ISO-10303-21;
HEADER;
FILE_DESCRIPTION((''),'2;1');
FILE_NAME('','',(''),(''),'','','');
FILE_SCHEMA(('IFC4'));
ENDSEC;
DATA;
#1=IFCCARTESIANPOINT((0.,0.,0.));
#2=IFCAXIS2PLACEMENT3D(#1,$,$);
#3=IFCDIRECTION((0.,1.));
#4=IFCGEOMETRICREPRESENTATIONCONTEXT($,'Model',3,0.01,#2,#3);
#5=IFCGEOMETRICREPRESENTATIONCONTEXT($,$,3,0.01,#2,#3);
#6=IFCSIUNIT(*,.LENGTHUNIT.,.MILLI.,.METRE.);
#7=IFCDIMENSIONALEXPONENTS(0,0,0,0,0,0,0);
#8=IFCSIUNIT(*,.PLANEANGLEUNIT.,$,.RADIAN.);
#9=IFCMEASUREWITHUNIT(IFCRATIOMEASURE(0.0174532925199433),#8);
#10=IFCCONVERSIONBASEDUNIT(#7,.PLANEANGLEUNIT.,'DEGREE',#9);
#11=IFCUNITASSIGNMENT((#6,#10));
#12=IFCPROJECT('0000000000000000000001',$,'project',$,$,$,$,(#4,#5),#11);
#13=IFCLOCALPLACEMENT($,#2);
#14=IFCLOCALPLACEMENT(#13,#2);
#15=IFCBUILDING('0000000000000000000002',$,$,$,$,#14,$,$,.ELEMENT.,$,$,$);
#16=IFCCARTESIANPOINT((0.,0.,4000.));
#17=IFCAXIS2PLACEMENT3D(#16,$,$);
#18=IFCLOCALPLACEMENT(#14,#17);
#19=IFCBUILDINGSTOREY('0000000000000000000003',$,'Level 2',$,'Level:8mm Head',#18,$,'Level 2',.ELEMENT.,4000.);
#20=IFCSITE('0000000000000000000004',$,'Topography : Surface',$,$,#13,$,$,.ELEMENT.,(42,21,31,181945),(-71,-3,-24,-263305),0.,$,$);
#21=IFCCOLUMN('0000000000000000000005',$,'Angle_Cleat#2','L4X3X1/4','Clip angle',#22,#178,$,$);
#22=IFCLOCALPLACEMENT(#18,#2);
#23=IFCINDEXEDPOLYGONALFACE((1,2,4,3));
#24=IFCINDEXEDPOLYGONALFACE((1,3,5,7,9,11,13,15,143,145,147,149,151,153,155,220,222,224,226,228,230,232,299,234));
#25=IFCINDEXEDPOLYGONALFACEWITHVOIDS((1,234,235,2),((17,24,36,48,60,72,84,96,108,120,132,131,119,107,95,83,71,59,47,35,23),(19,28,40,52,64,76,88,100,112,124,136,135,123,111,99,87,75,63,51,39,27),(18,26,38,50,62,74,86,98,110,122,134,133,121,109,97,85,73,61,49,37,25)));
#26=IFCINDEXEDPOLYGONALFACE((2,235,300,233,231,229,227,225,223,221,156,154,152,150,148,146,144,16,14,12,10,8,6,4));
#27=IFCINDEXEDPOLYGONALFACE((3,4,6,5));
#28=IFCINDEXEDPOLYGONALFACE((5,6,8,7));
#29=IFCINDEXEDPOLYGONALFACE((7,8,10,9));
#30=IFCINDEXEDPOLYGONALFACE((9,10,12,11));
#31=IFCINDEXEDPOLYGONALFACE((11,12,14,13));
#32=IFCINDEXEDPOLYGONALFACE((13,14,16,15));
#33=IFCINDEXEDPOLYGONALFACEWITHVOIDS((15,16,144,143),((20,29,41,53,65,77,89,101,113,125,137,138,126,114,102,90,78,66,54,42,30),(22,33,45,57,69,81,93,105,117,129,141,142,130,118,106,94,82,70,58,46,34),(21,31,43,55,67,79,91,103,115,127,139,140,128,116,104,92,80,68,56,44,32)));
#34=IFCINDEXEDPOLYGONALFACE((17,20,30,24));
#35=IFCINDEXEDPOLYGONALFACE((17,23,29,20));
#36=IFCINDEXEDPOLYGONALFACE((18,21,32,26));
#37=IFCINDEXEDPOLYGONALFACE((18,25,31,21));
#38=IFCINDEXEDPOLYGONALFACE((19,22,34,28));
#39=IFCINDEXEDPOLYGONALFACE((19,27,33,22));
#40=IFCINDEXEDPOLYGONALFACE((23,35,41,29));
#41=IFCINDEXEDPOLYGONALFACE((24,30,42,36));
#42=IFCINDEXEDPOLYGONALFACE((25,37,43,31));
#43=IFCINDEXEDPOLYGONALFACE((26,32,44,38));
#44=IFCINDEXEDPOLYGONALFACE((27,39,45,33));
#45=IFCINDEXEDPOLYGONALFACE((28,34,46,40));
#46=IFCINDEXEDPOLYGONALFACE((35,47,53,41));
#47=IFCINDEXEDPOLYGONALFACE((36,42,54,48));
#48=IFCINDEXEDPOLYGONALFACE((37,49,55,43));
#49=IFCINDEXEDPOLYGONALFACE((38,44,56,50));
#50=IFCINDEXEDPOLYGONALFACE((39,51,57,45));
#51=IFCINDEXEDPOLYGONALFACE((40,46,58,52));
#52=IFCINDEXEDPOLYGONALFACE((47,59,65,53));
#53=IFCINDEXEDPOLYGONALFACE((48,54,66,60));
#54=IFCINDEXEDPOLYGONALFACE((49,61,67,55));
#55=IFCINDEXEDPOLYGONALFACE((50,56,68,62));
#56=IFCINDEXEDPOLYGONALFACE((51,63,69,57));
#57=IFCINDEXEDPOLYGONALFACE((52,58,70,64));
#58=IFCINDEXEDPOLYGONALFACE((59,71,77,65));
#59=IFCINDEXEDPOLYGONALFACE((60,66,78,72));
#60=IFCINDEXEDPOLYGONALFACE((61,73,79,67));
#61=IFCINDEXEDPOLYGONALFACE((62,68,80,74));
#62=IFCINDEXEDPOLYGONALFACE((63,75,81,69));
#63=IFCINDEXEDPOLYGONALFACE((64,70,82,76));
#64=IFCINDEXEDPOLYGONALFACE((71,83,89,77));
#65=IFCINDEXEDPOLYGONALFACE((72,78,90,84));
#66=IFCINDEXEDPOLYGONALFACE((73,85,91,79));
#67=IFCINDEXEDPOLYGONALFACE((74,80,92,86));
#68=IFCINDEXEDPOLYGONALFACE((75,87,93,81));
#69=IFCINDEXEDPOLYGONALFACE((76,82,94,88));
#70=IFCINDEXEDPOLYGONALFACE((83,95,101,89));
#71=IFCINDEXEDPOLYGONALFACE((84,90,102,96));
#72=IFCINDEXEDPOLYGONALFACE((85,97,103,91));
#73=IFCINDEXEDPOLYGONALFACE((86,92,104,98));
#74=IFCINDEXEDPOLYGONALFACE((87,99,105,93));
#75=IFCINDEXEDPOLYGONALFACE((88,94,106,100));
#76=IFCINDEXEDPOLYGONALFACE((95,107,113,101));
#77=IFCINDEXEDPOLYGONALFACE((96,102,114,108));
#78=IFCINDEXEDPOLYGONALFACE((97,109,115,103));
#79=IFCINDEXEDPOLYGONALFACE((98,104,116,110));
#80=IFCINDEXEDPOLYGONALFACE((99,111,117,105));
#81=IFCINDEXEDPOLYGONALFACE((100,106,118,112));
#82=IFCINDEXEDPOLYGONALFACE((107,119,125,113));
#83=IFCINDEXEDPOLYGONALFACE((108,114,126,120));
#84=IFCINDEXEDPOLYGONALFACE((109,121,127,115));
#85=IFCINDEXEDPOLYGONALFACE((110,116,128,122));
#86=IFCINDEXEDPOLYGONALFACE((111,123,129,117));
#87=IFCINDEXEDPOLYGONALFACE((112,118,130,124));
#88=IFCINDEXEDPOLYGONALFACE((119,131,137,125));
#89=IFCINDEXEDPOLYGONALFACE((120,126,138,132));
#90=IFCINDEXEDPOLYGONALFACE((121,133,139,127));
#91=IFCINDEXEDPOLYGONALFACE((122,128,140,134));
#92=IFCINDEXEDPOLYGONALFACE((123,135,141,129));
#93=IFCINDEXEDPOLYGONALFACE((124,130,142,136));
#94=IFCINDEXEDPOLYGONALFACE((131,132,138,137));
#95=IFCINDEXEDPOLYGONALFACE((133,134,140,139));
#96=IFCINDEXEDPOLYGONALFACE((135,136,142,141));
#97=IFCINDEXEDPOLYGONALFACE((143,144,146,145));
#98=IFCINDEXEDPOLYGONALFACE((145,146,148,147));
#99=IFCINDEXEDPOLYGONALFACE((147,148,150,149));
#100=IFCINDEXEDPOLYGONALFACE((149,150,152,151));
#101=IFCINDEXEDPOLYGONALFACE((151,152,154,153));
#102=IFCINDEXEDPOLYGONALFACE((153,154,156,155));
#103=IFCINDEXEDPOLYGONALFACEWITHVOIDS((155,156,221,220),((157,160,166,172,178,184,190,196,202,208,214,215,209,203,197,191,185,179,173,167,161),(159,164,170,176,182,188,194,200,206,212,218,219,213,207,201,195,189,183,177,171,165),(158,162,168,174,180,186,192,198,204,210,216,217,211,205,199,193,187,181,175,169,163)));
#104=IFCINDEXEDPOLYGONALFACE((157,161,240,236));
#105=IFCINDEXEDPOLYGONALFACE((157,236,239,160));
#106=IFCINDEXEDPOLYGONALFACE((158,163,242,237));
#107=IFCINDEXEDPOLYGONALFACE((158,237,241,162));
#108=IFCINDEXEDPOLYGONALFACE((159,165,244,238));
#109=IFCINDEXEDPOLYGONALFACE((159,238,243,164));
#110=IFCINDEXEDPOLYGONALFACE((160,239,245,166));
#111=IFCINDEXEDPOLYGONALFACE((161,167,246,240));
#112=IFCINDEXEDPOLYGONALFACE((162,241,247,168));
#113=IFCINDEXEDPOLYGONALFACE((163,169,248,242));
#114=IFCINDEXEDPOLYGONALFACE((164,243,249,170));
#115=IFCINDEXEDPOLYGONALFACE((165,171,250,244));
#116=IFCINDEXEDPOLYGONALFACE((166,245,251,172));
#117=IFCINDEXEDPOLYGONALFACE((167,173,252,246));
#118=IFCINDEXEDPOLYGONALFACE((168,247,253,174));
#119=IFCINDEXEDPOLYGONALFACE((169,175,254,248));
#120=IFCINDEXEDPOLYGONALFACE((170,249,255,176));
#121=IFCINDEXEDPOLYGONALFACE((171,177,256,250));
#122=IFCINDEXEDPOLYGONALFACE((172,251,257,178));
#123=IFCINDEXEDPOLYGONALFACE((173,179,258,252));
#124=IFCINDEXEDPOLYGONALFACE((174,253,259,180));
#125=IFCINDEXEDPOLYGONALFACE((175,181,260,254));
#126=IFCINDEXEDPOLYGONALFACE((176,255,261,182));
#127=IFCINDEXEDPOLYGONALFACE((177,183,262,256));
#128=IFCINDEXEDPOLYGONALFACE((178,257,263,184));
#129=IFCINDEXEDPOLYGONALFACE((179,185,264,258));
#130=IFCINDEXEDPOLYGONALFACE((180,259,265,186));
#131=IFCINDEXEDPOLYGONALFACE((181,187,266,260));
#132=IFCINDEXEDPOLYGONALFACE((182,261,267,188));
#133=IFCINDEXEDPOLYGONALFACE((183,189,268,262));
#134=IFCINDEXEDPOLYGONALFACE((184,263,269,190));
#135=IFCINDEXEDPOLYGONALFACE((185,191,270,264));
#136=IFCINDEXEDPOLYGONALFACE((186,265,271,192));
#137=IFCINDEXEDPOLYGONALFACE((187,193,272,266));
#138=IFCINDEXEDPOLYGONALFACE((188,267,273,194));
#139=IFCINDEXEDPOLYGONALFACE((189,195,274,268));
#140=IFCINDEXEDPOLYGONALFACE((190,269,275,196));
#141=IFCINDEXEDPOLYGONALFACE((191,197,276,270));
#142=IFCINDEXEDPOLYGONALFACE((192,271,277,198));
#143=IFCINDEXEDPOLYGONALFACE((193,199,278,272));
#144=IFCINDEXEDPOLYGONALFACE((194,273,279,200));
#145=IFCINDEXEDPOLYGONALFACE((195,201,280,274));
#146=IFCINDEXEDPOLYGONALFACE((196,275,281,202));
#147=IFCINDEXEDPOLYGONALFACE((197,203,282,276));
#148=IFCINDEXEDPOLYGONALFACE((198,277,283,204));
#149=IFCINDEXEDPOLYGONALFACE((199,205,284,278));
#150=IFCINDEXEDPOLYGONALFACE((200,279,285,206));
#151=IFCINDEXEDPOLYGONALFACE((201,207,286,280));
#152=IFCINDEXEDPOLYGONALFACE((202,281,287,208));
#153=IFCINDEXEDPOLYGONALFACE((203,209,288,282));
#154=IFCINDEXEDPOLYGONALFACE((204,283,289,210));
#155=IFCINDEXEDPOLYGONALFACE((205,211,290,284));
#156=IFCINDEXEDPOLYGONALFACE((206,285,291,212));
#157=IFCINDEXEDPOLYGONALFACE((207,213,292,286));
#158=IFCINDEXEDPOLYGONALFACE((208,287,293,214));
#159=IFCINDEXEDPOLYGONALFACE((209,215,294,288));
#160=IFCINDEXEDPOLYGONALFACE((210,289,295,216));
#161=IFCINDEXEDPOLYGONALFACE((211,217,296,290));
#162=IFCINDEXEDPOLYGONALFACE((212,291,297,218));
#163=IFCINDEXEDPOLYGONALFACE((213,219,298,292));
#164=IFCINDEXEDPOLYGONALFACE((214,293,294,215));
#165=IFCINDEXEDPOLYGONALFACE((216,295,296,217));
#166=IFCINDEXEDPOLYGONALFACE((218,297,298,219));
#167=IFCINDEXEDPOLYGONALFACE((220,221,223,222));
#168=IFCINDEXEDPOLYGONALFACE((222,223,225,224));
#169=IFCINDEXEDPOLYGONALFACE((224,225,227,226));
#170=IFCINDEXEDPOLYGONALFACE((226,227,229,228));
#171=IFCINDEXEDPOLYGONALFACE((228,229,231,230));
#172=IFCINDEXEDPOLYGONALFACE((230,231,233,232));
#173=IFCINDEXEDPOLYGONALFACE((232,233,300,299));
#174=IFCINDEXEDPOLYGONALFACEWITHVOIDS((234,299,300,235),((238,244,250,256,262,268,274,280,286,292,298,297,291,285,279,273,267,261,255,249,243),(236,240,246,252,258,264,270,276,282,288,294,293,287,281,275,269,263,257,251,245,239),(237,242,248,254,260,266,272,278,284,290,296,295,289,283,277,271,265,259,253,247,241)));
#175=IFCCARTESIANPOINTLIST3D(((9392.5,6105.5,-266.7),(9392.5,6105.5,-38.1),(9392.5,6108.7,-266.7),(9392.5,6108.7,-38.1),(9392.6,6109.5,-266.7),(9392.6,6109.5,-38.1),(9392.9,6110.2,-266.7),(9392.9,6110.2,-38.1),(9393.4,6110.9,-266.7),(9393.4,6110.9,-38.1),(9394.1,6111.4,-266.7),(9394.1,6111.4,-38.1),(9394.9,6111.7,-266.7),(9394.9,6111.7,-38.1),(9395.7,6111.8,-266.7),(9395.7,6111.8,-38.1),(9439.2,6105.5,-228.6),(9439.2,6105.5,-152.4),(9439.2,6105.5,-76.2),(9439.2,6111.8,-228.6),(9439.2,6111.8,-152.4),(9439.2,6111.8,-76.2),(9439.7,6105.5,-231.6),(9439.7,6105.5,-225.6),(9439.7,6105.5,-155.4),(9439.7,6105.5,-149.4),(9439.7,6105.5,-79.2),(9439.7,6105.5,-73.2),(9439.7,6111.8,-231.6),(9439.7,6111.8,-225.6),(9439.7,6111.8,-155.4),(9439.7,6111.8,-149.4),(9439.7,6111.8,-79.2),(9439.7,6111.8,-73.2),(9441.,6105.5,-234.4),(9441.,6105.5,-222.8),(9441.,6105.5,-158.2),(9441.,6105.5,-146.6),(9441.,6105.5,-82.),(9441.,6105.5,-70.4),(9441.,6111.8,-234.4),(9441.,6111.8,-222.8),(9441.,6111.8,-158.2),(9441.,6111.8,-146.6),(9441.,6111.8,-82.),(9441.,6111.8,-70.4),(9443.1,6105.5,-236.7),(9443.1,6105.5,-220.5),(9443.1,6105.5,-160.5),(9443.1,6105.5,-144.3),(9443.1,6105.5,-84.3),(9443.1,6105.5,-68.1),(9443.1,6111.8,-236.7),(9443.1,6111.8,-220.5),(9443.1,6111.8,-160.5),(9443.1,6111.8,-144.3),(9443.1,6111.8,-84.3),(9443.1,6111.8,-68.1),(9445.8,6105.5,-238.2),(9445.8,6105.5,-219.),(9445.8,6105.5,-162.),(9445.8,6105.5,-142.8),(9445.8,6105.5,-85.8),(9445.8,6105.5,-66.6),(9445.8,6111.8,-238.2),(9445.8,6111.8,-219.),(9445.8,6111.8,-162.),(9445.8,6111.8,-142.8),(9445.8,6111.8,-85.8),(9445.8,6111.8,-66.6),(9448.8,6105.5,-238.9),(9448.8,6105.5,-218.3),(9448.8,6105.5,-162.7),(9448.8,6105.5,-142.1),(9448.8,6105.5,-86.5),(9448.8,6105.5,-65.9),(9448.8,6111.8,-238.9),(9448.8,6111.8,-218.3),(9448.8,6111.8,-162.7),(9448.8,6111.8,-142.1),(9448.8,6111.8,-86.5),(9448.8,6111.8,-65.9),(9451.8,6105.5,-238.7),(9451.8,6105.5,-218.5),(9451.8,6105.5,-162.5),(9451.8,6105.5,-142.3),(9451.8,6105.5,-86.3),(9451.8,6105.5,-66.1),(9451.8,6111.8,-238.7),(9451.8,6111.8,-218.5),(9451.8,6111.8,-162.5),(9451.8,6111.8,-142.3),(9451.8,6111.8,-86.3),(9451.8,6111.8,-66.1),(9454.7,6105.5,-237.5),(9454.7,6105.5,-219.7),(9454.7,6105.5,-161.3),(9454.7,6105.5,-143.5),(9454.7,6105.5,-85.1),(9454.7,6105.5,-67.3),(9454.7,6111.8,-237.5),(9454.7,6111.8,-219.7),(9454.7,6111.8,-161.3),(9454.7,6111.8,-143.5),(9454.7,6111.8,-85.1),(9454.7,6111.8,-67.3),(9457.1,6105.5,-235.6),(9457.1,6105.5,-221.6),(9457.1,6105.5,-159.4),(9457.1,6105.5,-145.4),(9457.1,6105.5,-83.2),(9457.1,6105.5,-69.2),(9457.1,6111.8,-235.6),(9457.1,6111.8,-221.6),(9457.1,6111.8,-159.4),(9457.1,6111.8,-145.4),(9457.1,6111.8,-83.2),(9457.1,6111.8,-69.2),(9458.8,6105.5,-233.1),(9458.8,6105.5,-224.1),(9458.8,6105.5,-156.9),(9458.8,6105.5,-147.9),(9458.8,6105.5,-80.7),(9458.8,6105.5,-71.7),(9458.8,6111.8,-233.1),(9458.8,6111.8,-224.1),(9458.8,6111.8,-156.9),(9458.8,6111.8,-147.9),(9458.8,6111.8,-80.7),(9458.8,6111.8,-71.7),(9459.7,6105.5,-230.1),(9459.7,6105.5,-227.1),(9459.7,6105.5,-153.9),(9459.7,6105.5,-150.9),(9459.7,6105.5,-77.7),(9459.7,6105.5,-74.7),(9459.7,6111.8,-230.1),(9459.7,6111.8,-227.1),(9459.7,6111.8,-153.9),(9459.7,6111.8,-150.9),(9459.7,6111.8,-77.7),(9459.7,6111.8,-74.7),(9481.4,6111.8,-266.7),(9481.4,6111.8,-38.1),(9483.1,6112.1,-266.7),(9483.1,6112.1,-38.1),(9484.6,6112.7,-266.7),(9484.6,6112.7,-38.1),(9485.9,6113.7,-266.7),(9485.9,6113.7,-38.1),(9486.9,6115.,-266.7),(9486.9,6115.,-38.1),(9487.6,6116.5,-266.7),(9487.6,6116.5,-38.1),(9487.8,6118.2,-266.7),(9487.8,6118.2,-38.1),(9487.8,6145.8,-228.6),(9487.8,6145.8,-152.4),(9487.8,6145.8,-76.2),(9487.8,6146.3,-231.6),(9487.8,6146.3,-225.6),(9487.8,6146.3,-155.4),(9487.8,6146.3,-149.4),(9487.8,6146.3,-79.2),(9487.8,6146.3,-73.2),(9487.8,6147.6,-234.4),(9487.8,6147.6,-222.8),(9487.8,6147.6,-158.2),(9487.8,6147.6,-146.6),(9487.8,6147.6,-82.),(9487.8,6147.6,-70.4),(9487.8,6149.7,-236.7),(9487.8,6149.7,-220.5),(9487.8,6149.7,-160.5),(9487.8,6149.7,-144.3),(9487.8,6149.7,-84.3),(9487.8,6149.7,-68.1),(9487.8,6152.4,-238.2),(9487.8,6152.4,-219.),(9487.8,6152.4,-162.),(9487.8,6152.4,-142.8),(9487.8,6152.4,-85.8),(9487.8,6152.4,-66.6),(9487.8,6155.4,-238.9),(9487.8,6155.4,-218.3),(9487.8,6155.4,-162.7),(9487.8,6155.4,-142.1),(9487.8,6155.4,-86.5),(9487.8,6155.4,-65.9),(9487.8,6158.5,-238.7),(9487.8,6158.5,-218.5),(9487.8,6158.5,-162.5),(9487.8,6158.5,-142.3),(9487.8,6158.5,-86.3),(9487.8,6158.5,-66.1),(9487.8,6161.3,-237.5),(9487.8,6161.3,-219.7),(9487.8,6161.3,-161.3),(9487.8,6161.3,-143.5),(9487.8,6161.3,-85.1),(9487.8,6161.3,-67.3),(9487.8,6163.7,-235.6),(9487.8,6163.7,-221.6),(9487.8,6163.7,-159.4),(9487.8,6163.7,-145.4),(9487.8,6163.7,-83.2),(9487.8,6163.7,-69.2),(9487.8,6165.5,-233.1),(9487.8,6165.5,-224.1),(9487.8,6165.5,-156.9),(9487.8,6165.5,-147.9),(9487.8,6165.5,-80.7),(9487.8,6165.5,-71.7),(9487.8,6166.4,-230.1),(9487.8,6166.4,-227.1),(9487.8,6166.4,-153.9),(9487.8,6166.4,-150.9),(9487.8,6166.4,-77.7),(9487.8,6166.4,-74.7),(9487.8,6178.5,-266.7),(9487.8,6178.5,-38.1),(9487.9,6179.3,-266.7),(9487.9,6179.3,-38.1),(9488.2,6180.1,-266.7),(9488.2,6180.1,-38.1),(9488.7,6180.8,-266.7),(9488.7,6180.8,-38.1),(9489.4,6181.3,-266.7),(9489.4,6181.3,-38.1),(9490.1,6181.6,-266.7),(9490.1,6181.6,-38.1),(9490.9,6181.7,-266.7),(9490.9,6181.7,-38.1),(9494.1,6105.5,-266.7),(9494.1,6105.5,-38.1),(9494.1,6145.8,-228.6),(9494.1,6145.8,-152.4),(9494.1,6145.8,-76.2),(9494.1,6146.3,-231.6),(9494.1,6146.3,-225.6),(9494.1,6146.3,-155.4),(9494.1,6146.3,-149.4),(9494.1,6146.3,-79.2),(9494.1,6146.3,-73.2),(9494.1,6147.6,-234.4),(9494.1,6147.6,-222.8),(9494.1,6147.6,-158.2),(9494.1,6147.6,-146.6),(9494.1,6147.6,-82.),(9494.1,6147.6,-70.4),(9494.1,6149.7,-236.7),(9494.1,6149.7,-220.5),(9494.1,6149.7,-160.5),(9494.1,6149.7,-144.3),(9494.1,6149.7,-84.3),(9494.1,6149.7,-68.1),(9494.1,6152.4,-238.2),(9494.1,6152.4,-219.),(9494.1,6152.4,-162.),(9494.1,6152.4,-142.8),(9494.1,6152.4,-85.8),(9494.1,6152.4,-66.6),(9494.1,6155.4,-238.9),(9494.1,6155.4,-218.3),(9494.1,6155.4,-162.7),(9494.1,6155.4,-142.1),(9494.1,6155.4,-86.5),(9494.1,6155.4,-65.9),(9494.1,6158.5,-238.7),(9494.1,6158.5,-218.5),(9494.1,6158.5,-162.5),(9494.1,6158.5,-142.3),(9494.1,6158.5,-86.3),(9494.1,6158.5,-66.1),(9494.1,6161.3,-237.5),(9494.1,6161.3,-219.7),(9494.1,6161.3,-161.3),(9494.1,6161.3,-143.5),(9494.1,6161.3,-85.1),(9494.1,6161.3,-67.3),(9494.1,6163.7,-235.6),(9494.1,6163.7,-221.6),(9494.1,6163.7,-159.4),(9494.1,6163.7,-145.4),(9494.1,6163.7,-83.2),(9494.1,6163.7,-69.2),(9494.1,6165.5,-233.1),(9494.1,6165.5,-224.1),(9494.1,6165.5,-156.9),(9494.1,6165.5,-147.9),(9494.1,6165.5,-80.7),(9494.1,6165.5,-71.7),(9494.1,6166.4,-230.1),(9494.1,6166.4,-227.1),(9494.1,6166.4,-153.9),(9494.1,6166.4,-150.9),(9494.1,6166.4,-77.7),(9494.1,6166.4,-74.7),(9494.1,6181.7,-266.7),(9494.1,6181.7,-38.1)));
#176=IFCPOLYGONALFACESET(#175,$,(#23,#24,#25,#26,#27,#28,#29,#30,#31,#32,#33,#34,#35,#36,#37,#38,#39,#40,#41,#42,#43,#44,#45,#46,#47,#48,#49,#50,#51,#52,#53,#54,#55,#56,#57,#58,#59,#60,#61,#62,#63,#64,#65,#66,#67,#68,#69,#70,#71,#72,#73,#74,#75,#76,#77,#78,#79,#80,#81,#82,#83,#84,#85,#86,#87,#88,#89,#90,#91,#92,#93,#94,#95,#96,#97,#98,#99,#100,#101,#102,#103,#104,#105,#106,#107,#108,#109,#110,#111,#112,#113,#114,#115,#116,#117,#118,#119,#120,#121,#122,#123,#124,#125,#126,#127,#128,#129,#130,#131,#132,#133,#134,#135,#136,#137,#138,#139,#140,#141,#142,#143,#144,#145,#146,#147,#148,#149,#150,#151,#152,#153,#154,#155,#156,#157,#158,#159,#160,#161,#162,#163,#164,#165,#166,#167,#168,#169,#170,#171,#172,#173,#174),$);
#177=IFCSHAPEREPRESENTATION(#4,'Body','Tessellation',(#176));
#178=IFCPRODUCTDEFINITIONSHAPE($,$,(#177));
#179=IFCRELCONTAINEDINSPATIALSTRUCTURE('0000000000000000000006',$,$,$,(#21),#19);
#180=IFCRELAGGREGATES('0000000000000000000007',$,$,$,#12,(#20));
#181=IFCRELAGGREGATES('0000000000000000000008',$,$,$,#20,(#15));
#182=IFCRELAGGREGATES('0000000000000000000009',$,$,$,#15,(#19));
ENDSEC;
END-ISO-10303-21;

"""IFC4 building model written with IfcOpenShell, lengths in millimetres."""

from ifc_helpers import new_model, entity, si_unit, converted_unit, direction, frame, frame_2d, origin, origin_2d_with_axis, place, context, project, spatial, circle, l_section, extrude, element, save


model = new_model("IFC4")

# Units and contexts
model_context = context("Model", 3, precision=0.01, world=origin(), true_north=direction((0.0, 1.0)))
context_of_model = context(None, 3, precision=0.01, world=origin(), true_north=direction((0.0, 1.0)))
ifc_project = project(units=[si_unit("LENGTHUNIT", "METRE", prefix="MILLI"), converted_unit("PLANEANGLEUNIT", "DEGREE", entity("IfcRatioMeasure", 0.0174532925199433), si_unit("PLANEANGLEUNIT", "RADIAN"), dimensions=[0, 0, 0, 0, 0, 0, 0])], contexts=[model_context, context_of_model])

# Site, building, storey
site_placement = place(None, origin())
site = spatial("IfcSite", under=ifc_project, at=site_placement, Name="Topography : Surface", CompositionType="ELEMENT", RefLatitude=(42, 21, 31, 181945), RefLongitude=(-71, -3, -24, -263305), RefElevation=0.0)
building_placement = place(site_placement, origin())
building = spatial("IfcBuilding", under=site, at=building_placement, CompositionType="ELEMENT")
storey_placement = place(building_placement, frame((0.0, 0.0, 4000.0)))
storey = spatial("IfcBuildingStorey", under=building, at=storey_placement, Name="Level 2", ObjectType="Level:8mm Head", LongName="Level 2", CompositionType="ELEMENT", Elevation=4000.0)

# Column, openings
column_1_placement = place(storey_placement, frame((9463.0, 6123.8, -38.1), z_axis=(0.0, 0.0, 1.0), x_axis=(0.0, 1.0, 0.0)))
column_1 = element("IfcColumn", 1, at=column_1_placement, inside=storey, Name="Angle_Cleat#2", Description="L4X3X1/4", ObjectType="Clip angle", context=model_context, shape_type="SweptSolid", body=[
    extrude(l_section(Depth=101.6, Width=76.2, Thickness=6.3, FilletRadius=6.3, EdgeRadius=3.2, at=frame_2d((19.8, 19.7))), origin(), (0.0, 0.0, -1.0), 228.6),
])
opening_1_placement = place(column_1_placement, frame((32.4, -31.5, -114.3), z_axis=(0.0, 1.0, 0.0), x_axis=(-1.0, 0.0, 0.0)))
element("IfcOpeningElement", 2, at=opening_1_placement, cuts=column_1, ObjectType="Opening", context=model_context, shape_type="SweptSolid", body=[
    extrude(circle(Radius=10.3, at=origin_2d_with_axis()), origin(), (0.0, 0.0, 1.0), 7.3),
])
opening_2_placement = place(column_1_placement, frame((32.4, -31.5, -114.3), z_axis=(0.0, 1.0, 0.0), x_axis=(-1.0, 0.0, 0.0)))
element("IfcOpeningElement", 3, at=opening_2_placement, cuts=column_1, ObjectType="Opening", context=model_context, shape_type="SweptSolid", body=[
    extrude(circle(Radius=10.3, at=frame_2d((0.0, 76.2), x_axis=(1.0, 0.0))), origin(), (0.0, 0.0, 1.0), 7.3),
])
opening_3_placement = place(column_1_placement, frame((32.4, -31.5, -114.3), z_axis=(0.0, 1.0, 0.0), x_axis=(-1.0, 0.0, 0.0)))
element("IfcOpeningElement", 4, at=opening_3_placement, cuts=column_1, ObjectType="Opening", context=model_context, shape_type="SweptSolid", body=[
    extrude(circle(Radius=10.3, at=frame_2d((0.0, -76.2), x_axis=(1.0, 0.0))), origin(), (0.0, 0.0, 1.0), 7.3),
])
opening_4_placement = place(column_1_placement, frame((-11.6, 13.5, -114.3), z_axis=(-1.0, 0.0, 0.0), x_axis=(0.0, 1.0, 0.0)))
element("IfcOpeningElement", 5, at=opening_4_placement, cuts=column_1, ObjectType="Opening", context=model_context, shape_type="SweptSolid", body=[
    extrude(circle(Radius=10.3, at=origin_2d_with_axis()), origin(), (0.0, 0.0, 1.0), 7.3),
])
opening_5_placement = place(column_1_placement, frame((-11.6, 13.5, -114.3), z_axis=(-1.0, 0.0, 0.0), x_axis=(0.0, 1.0, 0.0)))
element("IfcOpeningElement", 6, at=opening_5_placement, cuts=column_1, ObjectType="Opening", context=model_context, shape_type="SweptSolid", body=[
    extrude(circle(Radius=10.3, at=frame_2d((0.0, 76.2), x_axis=(1.0, 0.0))), origin(), (0.0, 0.0, 1.0), 7.3),
])
opening_6_placement = place(column_1_placement, frame((-11.6, 13.5, -114.3), z_axis=(-1.0, 0.0, 0.0), x_axis=(0.0, 1.0, 0.0)))
element("IfcOpeningElement", 7, at=opening_6_placement, cuts=column_1, ObjectType="Opening", context=model_context, shape_type="SweptSolid", body=[
    extrude(circle(Radius=10.3, at=frame_2d((0.0, -76.2), x_axis=(1.0, 0.0))), origin(), (0.0, 0.0, 1.0), 7.3),
])

save(model, "model.ifc")
